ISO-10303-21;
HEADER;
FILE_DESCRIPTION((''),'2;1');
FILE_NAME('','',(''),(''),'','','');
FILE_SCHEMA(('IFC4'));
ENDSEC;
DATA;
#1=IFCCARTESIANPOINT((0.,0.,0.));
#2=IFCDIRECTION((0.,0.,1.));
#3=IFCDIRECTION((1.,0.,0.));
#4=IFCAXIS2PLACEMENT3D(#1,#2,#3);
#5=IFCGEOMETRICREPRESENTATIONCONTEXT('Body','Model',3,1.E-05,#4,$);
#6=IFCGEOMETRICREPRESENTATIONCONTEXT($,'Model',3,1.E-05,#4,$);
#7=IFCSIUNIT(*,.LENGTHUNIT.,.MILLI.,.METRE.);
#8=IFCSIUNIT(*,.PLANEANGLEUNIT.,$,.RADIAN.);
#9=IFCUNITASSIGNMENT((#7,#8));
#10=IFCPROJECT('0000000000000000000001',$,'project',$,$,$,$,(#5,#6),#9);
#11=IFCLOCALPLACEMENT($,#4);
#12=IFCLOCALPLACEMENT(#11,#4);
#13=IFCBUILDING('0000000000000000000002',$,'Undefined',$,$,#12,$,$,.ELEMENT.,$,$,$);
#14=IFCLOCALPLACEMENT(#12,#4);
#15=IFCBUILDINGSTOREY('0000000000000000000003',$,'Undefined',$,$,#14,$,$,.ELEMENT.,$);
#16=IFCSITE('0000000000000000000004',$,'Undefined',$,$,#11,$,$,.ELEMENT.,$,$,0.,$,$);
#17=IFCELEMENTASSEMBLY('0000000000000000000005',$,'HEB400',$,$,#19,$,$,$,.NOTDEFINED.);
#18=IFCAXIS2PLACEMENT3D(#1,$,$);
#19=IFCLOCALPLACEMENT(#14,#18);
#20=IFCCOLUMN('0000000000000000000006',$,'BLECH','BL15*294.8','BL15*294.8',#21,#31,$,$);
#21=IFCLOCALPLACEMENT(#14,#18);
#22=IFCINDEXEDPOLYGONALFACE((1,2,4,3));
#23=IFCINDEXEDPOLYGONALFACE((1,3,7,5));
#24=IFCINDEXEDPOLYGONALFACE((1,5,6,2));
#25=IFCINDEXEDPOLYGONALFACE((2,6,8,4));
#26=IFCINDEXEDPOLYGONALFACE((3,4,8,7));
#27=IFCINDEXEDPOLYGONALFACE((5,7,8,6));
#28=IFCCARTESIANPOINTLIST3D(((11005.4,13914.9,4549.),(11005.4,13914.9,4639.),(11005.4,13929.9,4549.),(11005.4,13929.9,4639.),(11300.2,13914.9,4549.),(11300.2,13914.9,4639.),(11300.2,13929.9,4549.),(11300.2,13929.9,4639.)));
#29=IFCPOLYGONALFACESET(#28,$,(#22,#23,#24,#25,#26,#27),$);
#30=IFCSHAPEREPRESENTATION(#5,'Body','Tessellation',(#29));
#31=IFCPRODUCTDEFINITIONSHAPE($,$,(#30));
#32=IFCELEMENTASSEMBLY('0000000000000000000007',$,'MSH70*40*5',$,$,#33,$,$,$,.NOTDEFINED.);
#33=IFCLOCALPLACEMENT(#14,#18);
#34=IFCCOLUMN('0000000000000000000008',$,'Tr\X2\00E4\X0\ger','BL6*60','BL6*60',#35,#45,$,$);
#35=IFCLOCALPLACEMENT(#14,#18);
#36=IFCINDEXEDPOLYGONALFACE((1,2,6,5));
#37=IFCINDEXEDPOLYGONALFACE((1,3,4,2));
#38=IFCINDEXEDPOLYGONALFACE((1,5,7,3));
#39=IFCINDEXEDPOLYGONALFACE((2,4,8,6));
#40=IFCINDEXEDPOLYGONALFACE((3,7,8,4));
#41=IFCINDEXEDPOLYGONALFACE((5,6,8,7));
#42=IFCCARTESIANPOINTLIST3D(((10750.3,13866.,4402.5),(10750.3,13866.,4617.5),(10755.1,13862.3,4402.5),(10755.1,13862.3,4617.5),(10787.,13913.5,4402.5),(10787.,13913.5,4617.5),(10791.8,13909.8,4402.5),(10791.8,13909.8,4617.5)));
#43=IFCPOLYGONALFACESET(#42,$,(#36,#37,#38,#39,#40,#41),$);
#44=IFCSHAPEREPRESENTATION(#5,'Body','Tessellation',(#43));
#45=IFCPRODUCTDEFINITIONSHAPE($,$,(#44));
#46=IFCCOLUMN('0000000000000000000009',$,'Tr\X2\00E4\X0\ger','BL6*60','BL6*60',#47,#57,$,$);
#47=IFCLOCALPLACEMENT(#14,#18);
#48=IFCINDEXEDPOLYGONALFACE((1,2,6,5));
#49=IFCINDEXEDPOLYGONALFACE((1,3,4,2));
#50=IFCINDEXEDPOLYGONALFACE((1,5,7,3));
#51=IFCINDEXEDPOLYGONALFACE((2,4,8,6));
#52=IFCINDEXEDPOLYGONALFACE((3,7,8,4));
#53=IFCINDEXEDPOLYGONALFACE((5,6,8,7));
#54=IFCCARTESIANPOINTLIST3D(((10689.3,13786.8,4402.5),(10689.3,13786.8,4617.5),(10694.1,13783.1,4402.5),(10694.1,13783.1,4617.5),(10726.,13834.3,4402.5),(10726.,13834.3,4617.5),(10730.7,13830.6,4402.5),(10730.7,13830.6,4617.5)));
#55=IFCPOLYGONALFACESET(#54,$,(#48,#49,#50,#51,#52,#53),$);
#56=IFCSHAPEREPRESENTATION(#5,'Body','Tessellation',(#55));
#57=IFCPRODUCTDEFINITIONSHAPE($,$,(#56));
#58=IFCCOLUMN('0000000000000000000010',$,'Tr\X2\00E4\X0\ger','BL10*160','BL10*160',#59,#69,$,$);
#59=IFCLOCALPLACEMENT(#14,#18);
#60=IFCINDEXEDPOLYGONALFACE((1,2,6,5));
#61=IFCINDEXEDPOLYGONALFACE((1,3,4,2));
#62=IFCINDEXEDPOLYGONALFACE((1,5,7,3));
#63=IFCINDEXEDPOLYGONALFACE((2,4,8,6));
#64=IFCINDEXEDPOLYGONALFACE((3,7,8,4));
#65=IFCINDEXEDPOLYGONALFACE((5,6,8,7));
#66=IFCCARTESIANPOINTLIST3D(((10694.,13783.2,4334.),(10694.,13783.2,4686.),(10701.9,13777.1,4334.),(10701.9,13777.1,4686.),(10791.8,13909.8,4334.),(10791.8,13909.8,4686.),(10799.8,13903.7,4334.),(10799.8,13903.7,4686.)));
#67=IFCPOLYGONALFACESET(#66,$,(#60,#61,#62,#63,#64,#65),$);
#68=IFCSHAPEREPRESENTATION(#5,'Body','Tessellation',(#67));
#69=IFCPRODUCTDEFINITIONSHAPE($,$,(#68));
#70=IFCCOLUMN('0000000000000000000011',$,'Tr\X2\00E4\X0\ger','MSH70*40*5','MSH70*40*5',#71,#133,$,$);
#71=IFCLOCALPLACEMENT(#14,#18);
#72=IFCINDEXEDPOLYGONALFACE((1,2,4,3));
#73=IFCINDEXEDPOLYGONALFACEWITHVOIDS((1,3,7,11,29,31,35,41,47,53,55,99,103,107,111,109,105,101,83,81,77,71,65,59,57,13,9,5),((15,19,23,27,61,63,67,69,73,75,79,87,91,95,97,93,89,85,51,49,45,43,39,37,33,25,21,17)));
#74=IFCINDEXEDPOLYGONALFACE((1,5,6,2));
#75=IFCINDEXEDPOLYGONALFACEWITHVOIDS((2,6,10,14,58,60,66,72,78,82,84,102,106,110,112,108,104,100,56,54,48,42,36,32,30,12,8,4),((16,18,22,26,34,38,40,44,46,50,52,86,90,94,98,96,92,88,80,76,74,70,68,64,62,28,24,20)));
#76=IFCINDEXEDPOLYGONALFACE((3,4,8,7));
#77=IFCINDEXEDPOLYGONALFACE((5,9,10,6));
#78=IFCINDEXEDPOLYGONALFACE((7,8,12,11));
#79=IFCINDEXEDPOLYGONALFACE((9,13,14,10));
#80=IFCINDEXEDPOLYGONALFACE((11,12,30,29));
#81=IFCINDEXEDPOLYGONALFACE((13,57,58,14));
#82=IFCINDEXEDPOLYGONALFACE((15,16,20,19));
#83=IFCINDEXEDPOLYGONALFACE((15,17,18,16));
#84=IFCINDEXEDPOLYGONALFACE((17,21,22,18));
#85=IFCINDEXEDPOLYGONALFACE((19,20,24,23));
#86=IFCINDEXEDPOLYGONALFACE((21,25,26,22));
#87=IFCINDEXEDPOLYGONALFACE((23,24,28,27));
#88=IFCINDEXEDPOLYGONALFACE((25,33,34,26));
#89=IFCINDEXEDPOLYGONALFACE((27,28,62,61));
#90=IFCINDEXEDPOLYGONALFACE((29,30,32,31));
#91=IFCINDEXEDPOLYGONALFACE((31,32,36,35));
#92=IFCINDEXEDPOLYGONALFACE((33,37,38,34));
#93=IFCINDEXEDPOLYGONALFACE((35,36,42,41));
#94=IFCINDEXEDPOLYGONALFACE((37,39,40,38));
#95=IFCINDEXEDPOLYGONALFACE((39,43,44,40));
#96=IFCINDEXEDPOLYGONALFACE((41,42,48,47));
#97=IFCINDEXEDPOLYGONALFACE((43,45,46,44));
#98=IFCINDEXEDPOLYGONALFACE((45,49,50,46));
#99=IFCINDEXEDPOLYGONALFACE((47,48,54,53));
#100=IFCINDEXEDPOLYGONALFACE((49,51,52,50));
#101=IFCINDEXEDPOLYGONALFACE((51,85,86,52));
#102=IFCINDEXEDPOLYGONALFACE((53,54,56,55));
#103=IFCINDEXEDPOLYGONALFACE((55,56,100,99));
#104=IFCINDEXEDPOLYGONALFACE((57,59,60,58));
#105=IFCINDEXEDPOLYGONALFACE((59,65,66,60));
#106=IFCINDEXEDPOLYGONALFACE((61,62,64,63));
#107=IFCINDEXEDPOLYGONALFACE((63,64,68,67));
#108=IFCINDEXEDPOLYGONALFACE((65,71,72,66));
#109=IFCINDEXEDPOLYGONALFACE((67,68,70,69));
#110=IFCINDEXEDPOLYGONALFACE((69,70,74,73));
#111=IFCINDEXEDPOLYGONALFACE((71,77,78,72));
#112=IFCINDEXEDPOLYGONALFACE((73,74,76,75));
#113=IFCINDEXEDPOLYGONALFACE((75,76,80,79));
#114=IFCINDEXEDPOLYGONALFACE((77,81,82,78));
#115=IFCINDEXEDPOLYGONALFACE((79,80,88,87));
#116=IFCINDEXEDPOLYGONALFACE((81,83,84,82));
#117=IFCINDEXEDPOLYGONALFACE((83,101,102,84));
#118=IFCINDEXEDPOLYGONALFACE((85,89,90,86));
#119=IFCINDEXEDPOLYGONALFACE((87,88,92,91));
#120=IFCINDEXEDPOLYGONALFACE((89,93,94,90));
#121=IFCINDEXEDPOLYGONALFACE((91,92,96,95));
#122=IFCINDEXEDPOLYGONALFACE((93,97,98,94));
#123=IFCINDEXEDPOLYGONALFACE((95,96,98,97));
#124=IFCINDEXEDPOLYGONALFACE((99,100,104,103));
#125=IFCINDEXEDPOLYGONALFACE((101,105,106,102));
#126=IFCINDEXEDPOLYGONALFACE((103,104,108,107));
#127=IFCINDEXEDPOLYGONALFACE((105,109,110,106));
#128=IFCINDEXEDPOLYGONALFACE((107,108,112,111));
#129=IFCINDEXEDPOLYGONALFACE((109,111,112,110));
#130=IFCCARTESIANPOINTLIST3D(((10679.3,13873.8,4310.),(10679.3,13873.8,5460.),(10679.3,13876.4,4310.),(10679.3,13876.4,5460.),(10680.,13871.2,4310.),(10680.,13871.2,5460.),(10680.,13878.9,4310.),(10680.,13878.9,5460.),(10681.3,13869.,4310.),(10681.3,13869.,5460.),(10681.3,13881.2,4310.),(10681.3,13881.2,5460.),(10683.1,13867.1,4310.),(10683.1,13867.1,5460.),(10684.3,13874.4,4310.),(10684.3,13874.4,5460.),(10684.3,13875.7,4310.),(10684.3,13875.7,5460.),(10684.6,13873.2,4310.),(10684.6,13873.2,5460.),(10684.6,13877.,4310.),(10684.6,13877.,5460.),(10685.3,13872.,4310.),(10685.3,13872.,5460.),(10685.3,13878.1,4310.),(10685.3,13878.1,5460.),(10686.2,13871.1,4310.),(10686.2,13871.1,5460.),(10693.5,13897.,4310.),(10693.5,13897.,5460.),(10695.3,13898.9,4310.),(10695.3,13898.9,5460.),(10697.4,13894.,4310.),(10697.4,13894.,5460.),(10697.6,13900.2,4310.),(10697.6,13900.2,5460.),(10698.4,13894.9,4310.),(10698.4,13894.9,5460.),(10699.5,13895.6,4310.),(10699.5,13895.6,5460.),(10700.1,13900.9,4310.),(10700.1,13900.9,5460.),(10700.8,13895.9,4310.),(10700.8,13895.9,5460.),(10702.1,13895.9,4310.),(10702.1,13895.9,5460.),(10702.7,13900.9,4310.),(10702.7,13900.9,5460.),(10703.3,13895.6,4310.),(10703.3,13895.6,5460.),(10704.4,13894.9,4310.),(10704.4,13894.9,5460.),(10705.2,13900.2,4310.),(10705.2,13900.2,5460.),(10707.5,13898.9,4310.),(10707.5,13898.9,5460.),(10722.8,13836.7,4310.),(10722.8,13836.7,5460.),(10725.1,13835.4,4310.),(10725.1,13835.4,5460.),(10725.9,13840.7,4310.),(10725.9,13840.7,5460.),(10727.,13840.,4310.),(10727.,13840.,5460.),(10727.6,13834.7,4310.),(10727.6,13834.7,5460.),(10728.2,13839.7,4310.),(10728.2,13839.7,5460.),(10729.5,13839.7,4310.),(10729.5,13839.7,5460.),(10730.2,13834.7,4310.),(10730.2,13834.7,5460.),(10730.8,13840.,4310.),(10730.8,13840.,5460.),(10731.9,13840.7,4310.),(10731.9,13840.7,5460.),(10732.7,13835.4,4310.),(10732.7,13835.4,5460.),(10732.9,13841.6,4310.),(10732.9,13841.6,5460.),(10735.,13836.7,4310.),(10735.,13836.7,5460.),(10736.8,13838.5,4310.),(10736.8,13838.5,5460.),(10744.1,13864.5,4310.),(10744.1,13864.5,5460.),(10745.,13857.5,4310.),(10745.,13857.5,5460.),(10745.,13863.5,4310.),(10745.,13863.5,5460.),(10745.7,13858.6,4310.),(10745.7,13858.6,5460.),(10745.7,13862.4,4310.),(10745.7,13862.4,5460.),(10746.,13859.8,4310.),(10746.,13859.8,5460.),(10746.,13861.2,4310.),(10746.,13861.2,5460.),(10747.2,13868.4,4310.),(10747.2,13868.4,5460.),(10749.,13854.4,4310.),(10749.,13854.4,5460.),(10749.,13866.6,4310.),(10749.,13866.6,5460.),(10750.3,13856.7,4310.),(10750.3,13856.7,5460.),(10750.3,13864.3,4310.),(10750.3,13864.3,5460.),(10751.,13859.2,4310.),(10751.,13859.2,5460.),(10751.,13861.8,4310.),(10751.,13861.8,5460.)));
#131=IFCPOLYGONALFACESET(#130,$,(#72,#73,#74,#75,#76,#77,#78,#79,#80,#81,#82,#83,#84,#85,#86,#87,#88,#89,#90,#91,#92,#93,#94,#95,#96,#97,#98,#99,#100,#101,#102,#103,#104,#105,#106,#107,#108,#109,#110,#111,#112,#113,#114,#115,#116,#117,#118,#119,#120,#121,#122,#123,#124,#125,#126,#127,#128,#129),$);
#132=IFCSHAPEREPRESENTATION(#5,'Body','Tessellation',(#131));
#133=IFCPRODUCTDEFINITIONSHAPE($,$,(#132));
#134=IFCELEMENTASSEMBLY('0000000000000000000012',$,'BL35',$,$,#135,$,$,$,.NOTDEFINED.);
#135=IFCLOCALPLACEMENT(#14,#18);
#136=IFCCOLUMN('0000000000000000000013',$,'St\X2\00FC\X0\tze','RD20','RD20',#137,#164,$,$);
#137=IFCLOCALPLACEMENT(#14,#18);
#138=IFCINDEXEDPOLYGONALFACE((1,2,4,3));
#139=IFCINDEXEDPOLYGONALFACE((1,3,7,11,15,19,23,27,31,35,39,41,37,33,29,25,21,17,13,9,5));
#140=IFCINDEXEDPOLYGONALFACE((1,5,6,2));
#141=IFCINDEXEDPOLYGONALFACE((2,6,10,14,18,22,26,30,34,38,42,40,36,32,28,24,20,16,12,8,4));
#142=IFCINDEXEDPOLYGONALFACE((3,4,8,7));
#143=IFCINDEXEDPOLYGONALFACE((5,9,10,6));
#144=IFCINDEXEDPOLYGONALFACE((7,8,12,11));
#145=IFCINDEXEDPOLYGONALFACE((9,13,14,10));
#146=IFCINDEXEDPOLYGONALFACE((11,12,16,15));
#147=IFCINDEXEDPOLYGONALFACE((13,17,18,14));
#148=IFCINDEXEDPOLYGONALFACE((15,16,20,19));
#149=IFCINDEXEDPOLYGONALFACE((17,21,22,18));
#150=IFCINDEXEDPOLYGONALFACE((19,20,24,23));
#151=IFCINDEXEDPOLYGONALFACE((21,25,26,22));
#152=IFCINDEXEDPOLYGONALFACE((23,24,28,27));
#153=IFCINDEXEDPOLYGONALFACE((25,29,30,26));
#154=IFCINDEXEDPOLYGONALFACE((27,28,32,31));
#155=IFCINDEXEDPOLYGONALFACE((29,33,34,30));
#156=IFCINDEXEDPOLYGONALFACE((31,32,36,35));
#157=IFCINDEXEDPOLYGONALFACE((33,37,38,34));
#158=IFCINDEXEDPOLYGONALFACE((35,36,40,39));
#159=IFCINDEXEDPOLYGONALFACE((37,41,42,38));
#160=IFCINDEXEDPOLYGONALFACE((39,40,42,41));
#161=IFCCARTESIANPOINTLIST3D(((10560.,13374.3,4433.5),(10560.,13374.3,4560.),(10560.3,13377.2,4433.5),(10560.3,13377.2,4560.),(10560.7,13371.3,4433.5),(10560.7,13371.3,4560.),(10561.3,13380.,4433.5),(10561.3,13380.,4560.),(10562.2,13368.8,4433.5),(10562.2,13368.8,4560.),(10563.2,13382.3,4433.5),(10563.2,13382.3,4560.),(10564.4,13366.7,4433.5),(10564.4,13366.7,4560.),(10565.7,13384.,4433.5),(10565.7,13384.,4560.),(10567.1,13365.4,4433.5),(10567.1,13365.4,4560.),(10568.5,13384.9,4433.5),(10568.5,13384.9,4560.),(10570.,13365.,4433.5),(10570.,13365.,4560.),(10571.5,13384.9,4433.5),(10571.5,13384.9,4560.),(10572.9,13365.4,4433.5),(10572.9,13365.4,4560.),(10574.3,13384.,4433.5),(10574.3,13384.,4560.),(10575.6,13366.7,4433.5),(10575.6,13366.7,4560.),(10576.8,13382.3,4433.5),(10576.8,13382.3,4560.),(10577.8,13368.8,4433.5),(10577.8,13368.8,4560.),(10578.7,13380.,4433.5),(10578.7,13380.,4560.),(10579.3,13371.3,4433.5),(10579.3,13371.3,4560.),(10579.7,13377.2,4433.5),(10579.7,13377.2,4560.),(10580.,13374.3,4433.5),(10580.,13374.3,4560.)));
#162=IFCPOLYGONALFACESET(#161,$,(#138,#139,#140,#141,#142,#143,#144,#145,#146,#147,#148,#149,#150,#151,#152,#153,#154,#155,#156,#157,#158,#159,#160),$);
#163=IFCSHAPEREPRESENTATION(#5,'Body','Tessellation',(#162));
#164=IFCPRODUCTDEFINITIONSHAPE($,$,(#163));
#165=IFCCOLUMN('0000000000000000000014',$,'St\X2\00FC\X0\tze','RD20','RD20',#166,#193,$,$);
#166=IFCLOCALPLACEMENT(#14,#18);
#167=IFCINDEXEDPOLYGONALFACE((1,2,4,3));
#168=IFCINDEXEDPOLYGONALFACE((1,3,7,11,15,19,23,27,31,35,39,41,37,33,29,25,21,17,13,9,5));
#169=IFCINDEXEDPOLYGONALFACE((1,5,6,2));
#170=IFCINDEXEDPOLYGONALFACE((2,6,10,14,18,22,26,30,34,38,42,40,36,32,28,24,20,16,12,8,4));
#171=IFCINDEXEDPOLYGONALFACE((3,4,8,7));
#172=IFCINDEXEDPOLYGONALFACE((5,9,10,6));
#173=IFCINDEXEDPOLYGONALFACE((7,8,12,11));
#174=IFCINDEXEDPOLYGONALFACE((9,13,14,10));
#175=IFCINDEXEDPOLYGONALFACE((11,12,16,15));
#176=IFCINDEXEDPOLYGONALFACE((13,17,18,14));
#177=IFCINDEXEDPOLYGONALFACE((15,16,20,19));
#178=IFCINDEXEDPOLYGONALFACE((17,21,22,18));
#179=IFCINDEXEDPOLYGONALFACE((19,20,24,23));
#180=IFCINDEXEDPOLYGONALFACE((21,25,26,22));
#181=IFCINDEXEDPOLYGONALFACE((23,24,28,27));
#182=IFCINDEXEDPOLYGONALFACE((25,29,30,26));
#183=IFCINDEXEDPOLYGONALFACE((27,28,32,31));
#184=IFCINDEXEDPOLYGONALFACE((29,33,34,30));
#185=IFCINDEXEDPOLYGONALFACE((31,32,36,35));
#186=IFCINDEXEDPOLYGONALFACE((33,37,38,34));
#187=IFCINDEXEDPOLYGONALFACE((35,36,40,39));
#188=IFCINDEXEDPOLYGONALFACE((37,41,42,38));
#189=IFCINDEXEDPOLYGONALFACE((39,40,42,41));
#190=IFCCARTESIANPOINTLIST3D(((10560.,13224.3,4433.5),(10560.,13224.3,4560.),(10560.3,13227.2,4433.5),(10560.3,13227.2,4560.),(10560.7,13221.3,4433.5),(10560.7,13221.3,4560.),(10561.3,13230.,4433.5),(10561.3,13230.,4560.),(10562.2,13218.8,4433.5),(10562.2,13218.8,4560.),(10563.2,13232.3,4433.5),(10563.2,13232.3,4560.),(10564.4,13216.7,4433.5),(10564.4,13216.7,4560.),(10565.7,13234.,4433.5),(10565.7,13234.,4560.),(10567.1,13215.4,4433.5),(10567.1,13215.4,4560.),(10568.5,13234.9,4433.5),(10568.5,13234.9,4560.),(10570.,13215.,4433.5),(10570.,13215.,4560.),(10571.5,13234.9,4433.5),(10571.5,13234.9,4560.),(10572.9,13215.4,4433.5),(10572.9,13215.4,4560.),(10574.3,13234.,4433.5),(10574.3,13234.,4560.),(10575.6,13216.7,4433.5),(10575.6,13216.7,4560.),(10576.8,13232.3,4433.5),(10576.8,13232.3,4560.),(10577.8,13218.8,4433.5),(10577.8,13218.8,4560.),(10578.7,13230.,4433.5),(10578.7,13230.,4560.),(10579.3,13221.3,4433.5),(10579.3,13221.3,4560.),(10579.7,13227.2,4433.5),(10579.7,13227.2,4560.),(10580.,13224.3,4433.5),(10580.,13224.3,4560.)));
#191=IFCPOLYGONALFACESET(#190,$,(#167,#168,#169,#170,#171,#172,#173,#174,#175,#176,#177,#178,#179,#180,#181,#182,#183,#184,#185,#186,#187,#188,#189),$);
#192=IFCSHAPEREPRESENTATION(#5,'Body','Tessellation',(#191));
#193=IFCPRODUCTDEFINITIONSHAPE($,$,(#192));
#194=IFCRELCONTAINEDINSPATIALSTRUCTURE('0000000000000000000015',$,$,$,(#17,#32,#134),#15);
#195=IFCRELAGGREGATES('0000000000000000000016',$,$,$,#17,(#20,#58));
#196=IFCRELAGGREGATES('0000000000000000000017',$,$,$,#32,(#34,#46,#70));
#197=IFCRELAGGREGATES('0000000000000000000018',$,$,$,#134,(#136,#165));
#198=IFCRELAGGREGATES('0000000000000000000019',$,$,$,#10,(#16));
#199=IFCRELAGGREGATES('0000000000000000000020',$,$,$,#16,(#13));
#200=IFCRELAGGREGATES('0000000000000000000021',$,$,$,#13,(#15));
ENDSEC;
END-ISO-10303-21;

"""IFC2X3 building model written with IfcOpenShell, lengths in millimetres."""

from ifc_helpers import new_model, si_unit, frame, origin_with_axes, origin_2d_with_axis, place, context, project, spatial, rectangle, hollow_rectangle, circle, extrude, element, aggregate, save


model = new_model("IFC2X3")

# Units and contexts
model_context_1 = context("Model", 3, precision=1e-05, world=origin_with_axes(), identifier="Body")
model_context_2 = context("Model", 3, precision=1e-05, world=origin_with_axes())
ifc_project = project(units=[si_unit("LENGTHUNIT", "METRE", prefix="MILLI"), si_unit("PLANEANGLEUNIT", "RADIAN")], contexts=[model_context_1, model_context_2])

# Site, building, storey
site_placement = place(None, origin_with_axes())
site = spatial("IfcSite", under=ifc_project, at=site_placement, Name="Undefined", CompositionType="ELEMENT", RefElevation=0.0)
building_placement = place(site_placement, origin_with_axes())
building = spatial("IfcBuilding", under=site, at=building_placement, Name="Undefined", CompositionType="ELEMENT")
storey_placement = place(building_placement, origin_with_axes())
storey = spatial("IfcBuildingStorey", under=building, at=storey_placement, Name="Undefined", CompositionType="ELEMENT")

# Element assembly, column
assembly_1 = element("IfcElementAssembly", 1, inside=storey, Name="HEB400", PredefinedType="NOTDEFINED")
column_1_placement = place(storey_placement, frame((11152.8, 13922.4, 4549.0), z_axis=(0.0, 0.0, 1.0), x_axis=(1.0, 0.0, 0.0)))
column_1 = element("IfcColumn", 2, at=column_1_placement, Name="BLECH", Description="BL15*294.8", ObjectType="BL15*294.8", context=model_context_1, shape_type="SweptSolid", body=[
    extrude(rectangle(XDim=15.0, YDim=294.8, at=origin_2d_with_axis()), frame((0.0, 0.0, 90.0), z_axis=(0.0, 0.0, -1.0), x_axis=(0.0, -1.0, 0.0)), (0.0, 0.0, 1.0), 90.0),
])

# Element assembly, columns
assembly_2 = element("IfcElementAssembly", 3, inside=storey, Name="MSH70*40*5", PredefinedType="NOTDEFINED")
column_2_placement = place(storey_placement, frame((10771.1, 13887.9, 4402.5), z_axis=(0.0, 0.0, 1.0), x_axis=(1.0, 0.0, 0.0)))
column_2 = element("IfcColumn", 4, at=column_2_placement, Name="Träger", Description="BL6*60", ObjectType="BL6*60", context=model_context_1, shape_type="SweptSolid", body=[
    extrude(rectangle(XDim=6.0, YDim=60.0, at=origin_2d_with_axis()), frame((0.0, 0.0, 215.0), z_axis=(0.0, 0.0, -1.0), x_axis=(-0.791223, 0.611527, 0.0)), (0.0, 0.0, 1.0), 215.0),
])
column_3_placement = place(storey_placement, frame((10710.0, 13808.7, 4402.5), z_axis=(0.0, 0.0, 1.0), x_axis=(1.0, 0.0, 0.0)))
column_3 = element("IfcColumn", 5, at=column_3_placement, Name="Träger", Description="BL6*60", ObjectType="BL6*60", context=model_context_1, shape_type="SweptSolid", body=[
    extrude(rectangle(XDim=6.0, YDim=60.0, at=origin_2d_with_axis()), frame((0.0, 0.0, 215.0), z_axis=(0.0, 0.0, -1.0), x_axis=(-0.791223, 0.611527, 0.0)), (0.0, 0.0, 1.0), 215.0),
])

# Columns
column_4_placement = place(storey_placement, frame((10746.9, 13843.4, 4334.0), z_axis=(0.0, 0.0, 1.0), x_axis=(1.0, 0.0, 0.0)))
column_4 = element("IfcColumn", 6, at=column_4_placement, Name="Träger", Description="BL10*160", ObjectType="BL10*160", context=model_context_1, shape_type="SweptSolid", body=[
    extrude(rectangle(XDim=10.0, YDim=160.0, at=origin_2d_with_axis()), frame((0.0, 0.0, 352.0), z_axis=(0.0, 0.0, -1.0), x_axis=(-0.791223, 0.611527, 0.0)), (0.0, 0.0, 1.0), 352.0),
])
aggregate(assembly_1, [column_1, column_4])
column_5_placement = place(storey_placement, frame((10715.2, 13867.8, 4310.0), z_axis=(0.0, 0.0, 1.0), x_axis=(1.0, 0.0, 0.0)))
column_5 = element("IfcColumn", 7, at=column_5_placement, Name="Träger", Description="MSH70*40*5", ObjectType="MSH70*40*5", context=model_context_1, shape_type="SweptSolid", body=[
    extrude(hollow_rectangle(XDim=40.0, YDim=70.0, WallThickness=5.0, InnerFilletRadius=5.0, OuterFilletRadius=10.0, at=origin_2d_with_axis()), frame((0.0, 0.0, 1150.0), z_axis=(0.0, 0.0, -1.0), x_axis=(-0.608762, -0.793353, 0.0)), (0.0, 0.0, 1.0), 1150.0),
])
aggregate(assembly_2, [column_2, column_3, column_5])

# Element assembly, columns
assembly_3 = element("IfcElementAssembly", 8, inside=storey, Name="BL35", PredefinedType="NOTDEFINED")
column_6_placement = place(storey_placement, frame((10570.0, 13375.0, 4433.5), z_axis=(0.0, 0.0, 1.0), x_axis=(1.0, 0.0, 0.0)))
column_6 = element("IfcColumn", 9, at=column_6_placement, Name="Stütze", Description="RD20", ObjectType="RD20", context=model_context_1, shape_type="SweptSolid", body=[
    extrude(circle(Radius=10.0, at=origin_2d_with_axis()), frame((0.0, 0.0, 126.5), z_axis=(0.0, 0.0, -1.0), x_axis=(0.0, -1.0, 0.0)), (0.0, 0.0, 1.0), 126.5),
])
column_7_placement = place(storey_placement, frame((10570.0, 13225.0, 4433.5), z_axis=(0.0, 0.0, 1.0), x_axis=(1.0, 0.0, 0.0)))
column_7 = element("IfcColumn", 10, at=column_7_placement, Name="Stütze", Description="RD20", ObjectType="RD20", context=model_context_1, shape_type="SweptSolid", body=[
    extrude(circle(Radius=10.0, at=origin_2d_with_axis()), frame((0.0, 0.0, 126.5), z_axis=(0.0, 0.0, -1.0), x_axis=(0.0, -1.0, 0.0)), (0.0, 0.0, 1.0), 126.5),
])
aggregate(assembly_3, [column_6, column_7])

save(model, "model.ifc")
